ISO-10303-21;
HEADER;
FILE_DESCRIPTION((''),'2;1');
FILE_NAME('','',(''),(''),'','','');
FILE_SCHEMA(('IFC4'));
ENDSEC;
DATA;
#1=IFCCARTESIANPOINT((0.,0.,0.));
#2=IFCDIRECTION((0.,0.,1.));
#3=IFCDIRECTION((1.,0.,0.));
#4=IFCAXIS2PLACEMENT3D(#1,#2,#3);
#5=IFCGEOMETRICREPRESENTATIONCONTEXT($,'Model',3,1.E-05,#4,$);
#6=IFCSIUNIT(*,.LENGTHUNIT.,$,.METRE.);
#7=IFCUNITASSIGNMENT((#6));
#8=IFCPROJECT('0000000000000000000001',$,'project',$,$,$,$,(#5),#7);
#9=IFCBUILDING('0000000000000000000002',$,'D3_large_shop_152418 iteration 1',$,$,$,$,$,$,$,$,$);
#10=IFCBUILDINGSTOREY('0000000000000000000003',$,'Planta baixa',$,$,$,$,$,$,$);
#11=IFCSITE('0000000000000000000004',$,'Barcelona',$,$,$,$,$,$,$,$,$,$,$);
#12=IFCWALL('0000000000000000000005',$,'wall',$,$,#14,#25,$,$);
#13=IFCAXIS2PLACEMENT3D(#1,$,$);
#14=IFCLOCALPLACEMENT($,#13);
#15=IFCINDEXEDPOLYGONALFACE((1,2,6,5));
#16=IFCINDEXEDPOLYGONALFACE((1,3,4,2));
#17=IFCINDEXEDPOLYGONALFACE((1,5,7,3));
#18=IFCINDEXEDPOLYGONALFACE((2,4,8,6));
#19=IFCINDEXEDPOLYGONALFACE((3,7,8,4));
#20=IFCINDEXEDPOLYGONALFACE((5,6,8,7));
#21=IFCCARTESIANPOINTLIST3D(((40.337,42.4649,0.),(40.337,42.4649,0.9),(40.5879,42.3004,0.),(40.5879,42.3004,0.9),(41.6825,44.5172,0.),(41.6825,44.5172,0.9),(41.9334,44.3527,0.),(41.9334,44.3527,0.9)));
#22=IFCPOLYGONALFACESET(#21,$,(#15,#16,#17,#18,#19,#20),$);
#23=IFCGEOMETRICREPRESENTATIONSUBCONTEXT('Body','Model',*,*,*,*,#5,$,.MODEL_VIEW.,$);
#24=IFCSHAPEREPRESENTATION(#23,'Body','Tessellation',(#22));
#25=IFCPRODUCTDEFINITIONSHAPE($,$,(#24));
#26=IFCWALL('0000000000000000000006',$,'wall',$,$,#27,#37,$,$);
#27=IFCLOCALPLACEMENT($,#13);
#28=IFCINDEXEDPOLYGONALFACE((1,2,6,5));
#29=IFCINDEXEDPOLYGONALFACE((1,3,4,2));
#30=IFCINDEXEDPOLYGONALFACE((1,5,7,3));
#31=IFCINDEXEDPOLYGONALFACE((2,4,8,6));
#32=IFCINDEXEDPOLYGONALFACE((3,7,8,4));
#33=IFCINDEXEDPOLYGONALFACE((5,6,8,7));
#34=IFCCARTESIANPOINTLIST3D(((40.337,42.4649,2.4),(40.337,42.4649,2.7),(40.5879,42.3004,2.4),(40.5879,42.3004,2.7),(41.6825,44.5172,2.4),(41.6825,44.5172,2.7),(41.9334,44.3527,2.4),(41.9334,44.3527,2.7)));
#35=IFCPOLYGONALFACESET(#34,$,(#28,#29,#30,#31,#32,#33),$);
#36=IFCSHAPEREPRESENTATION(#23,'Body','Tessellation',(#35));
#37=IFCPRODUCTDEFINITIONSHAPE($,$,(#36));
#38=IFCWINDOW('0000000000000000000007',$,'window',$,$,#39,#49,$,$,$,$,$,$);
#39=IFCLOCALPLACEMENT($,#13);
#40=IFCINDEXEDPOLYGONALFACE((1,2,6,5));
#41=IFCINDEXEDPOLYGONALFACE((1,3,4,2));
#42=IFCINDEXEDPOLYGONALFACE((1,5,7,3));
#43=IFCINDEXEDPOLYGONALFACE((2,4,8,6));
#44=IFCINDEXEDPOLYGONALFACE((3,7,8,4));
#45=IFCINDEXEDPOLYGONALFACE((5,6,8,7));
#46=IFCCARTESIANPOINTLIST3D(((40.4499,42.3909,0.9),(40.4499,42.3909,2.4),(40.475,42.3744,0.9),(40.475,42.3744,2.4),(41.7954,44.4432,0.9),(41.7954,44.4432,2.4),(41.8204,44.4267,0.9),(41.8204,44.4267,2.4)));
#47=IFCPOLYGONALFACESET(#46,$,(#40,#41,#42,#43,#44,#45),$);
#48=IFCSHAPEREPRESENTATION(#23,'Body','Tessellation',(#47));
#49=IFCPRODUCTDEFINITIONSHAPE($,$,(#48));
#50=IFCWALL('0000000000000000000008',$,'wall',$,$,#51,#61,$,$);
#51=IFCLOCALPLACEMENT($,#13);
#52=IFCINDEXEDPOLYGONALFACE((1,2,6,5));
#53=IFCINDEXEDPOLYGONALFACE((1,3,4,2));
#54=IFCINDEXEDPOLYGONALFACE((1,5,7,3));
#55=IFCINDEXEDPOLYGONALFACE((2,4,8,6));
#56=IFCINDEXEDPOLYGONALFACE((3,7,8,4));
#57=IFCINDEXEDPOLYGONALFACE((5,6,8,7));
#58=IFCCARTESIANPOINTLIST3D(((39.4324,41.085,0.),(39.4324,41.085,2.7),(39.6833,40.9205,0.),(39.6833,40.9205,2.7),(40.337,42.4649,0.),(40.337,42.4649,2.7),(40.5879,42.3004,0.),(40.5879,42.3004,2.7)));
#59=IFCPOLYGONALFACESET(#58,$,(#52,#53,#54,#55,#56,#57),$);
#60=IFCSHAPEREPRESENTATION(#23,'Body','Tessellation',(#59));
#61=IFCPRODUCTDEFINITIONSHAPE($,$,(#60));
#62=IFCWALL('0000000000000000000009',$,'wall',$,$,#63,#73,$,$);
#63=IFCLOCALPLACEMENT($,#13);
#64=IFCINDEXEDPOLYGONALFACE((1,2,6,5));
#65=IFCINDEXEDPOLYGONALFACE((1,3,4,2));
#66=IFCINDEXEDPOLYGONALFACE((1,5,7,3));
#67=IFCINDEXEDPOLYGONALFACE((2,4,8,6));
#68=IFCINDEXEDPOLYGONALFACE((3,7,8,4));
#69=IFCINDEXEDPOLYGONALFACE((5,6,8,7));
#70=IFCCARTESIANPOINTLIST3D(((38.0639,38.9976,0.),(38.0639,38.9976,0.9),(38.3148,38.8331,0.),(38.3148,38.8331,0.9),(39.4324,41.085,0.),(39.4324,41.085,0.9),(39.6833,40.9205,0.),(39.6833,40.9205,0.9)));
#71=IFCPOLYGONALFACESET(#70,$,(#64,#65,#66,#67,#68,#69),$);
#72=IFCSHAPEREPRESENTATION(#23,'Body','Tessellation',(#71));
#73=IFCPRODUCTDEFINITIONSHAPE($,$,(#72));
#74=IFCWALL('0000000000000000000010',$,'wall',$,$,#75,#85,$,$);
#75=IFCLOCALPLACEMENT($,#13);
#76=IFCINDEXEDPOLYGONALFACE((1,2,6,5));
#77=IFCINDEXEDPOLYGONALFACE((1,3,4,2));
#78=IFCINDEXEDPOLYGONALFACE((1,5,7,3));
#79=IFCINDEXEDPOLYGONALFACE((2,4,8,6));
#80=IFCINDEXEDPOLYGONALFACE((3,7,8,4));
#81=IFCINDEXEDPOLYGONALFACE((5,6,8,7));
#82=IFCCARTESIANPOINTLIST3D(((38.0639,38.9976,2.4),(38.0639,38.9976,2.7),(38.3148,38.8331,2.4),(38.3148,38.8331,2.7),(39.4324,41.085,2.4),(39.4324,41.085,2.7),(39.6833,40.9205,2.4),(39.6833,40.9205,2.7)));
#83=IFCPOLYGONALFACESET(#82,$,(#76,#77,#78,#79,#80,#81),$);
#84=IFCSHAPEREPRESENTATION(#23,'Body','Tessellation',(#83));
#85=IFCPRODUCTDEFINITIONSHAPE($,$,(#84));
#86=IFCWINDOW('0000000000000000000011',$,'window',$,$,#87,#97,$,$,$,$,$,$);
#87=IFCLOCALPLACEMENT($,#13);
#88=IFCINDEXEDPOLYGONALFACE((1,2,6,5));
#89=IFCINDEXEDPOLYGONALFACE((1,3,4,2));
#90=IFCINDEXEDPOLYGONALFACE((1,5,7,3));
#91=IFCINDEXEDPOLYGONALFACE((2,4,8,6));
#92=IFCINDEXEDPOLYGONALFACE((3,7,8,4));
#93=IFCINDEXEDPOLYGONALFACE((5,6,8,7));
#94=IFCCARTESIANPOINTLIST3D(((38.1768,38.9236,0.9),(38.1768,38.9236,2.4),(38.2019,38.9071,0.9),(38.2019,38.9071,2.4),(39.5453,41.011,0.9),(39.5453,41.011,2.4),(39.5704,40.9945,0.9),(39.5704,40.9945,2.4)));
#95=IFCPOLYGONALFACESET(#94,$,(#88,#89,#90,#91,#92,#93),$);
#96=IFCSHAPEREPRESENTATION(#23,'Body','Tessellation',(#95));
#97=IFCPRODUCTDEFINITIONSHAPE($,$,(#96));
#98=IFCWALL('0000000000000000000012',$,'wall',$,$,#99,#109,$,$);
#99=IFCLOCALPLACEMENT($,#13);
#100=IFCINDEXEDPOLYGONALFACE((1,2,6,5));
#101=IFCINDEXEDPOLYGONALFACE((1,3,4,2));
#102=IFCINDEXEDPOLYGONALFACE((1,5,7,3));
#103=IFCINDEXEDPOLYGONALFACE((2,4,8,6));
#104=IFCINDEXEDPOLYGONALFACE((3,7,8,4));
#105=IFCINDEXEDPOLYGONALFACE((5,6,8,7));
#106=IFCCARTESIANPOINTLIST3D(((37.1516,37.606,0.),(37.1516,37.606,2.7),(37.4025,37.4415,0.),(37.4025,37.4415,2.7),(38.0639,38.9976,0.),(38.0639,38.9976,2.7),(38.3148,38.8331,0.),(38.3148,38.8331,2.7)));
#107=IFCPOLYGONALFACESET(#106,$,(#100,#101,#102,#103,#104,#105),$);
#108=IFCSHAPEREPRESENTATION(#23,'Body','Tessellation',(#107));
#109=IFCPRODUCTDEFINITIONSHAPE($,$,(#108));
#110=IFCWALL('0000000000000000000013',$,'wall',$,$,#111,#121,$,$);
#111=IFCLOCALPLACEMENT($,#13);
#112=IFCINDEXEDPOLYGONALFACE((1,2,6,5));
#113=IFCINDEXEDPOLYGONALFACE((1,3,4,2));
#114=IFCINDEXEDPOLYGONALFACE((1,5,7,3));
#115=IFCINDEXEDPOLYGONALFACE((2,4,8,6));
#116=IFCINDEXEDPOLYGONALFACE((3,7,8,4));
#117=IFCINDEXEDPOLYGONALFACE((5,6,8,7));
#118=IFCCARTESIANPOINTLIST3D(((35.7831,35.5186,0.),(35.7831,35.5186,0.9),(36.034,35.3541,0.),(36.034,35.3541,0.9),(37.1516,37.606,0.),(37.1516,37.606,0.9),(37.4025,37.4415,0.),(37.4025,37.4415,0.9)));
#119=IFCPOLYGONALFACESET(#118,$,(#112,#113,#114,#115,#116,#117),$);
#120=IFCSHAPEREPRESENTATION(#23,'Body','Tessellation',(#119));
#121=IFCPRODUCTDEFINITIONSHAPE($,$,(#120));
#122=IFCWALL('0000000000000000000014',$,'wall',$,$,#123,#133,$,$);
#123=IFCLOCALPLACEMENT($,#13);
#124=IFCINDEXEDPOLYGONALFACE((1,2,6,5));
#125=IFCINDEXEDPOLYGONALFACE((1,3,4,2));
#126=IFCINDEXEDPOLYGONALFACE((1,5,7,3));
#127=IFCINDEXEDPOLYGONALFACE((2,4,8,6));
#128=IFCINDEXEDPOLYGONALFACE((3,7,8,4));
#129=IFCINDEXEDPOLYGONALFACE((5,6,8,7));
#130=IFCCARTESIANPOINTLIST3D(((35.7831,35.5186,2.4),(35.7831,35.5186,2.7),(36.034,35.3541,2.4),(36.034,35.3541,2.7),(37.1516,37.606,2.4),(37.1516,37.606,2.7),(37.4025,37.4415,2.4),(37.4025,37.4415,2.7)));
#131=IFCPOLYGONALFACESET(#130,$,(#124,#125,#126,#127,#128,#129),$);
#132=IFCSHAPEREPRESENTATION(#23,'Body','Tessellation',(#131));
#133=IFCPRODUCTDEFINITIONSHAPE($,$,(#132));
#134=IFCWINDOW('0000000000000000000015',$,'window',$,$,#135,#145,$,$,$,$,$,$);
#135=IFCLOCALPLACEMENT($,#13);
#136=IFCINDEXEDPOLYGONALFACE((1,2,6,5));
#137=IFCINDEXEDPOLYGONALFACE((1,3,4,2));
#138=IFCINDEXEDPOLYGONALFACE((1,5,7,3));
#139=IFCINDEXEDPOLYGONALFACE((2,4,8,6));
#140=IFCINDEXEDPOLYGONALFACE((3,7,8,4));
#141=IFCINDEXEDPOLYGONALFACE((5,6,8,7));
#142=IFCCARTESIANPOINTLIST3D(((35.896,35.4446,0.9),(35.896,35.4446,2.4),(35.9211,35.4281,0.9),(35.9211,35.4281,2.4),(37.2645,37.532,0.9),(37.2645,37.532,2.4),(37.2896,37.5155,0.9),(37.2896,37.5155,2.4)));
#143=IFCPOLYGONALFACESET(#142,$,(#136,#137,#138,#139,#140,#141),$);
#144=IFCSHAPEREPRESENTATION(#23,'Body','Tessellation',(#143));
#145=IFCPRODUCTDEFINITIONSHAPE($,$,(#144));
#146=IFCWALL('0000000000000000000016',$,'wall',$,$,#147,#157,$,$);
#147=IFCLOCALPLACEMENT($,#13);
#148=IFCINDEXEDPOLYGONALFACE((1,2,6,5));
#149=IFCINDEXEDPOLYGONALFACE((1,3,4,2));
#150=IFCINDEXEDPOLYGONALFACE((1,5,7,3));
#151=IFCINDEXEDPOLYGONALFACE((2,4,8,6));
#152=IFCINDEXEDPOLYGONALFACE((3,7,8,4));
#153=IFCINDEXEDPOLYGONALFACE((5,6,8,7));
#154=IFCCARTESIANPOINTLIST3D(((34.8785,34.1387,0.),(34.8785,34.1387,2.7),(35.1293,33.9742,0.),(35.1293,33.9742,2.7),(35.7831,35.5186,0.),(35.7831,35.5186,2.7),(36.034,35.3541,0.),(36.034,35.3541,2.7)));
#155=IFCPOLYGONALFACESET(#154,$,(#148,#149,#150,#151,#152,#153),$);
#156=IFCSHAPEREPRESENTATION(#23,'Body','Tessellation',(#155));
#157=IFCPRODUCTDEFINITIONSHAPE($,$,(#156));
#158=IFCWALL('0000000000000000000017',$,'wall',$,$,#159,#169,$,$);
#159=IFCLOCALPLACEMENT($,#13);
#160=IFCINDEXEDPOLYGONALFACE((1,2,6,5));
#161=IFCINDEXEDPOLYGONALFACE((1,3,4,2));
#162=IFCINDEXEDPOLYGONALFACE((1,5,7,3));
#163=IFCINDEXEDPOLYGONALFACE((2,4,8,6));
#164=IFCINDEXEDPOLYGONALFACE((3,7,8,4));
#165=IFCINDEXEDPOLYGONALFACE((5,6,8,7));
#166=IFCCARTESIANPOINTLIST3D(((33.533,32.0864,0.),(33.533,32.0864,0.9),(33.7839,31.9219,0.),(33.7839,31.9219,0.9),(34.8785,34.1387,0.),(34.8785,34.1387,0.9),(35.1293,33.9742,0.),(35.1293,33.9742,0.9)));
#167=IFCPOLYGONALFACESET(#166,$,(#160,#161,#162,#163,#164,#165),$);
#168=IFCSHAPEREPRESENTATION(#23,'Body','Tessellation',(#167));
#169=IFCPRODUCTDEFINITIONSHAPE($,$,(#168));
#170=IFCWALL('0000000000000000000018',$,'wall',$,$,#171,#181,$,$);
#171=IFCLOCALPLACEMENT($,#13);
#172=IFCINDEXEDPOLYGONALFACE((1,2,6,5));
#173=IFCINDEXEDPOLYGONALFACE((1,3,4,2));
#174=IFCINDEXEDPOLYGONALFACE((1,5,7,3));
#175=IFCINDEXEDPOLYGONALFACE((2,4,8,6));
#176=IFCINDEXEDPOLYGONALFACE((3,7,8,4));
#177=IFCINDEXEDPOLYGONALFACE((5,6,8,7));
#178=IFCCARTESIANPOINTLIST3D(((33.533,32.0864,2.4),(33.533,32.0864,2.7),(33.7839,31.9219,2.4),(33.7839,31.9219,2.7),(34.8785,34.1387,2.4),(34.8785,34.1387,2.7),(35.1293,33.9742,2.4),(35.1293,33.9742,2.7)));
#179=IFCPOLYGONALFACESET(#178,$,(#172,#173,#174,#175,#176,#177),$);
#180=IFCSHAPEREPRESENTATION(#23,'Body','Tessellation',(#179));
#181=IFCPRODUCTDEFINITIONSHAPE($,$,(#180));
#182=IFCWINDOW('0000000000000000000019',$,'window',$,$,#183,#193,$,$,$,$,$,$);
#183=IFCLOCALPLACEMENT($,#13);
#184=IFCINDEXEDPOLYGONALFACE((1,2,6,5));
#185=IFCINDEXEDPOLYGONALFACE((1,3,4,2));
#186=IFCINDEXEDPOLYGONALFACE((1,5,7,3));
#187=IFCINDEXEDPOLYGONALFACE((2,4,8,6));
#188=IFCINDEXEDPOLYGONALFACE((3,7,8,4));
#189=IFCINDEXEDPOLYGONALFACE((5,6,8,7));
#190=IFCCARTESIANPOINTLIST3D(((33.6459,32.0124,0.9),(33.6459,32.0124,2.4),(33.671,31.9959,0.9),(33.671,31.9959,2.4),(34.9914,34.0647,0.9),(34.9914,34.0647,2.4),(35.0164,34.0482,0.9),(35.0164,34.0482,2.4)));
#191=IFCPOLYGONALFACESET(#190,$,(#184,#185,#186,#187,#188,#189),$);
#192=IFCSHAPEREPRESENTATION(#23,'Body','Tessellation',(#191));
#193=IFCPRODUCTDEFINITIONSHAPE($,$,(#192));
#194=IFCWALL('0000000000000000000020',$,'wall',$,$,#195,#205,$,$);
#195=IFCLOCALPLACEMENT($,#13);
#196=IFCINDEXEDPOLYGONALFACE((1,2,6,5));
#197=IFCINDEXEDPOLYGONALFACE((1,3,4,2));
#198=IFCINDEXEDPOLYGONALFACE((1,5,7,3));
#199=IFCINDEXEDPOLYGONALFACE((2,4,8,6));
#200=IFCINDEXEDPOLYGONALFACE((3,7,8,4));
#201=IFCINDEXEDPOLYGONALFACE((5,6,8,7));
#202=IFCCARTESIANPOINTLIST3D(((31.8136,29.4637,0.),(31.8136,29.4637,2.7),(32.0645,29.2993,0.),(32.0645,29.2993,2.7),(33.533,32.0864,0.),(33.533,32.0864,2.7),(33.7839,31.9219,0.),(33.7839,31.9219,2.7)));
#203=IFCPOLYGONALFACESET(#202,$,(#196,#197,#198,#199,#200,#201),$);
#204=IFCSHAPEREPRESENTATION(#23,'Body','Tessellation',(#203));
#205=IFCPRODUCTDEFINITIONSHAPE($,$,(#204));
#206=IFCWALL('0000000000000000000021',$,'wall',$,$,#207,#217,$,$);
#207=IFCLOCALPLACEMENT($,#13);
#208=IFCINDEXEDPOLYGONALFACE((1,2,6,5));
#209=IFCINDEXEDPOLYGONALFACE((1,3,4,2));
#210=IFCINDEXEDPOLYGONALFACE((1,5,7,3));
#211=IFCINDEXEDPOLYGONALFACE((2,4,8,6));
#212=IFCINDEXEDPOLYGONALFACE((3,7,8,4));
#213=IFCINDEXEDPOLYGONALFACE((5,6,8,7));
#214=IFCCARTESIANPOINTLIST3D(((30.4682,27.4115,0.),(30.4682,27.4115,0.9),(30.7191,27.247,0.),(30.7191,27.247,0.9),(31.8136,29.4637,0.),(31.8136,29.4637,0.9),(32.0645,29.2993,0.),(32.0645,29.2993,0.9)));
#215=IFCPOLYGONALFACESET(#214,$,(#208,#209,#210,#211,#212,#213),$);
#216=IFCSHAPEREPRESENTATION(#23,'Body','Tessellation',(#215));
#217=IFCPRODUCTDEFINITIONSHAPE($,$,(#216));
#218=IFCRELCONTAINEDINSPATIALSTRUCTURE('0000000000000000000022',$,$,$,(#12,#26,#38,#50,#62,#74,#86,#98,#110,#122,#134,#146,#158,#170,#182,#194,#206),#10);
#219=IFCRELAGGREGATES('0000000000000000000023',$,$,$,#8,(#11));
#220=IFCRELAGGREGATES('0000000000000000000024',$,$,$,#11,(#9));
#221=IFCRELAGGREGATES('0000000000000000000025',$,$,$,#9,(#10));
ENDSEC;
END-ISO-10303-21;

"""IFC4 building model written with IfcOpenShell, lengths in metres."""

from ifc_helpers import new_model, si_unit, frame, origin, origin_with_axes, place, context, subcontext, project, spatial, polyline, outline, extrude, element, save


model = new_model("IFC4")

# Units and contexts
model_context = context("Model", 3, precision=1e-05, world=origin_with_axes())
body_context = subcontext(model_context, "Body", "Model", "MODEL_VIEW")
ifc_project = project(units=[si_unit("LENGTHUNIT", "METRE")], contexts=[model_context])

# Site, building, storey
site = spatial("IfcSite", under=ifc_project, Name="Barcelona")
building = spatial("IfcBuilding", under=site, Name="D3_large_shop_152418 iteration 1")
storey = spatial("IfcBuildingStorey", under=building, Name="Planta baixa")

# Walls
wall_1_placement = place(None, origin_with_axes())
element("IfcWall", 1, at=wall_1_placement, inside=storey, Name="wall", context=body_context, shape_type="SweptSolid", body=[
    extrude(outline(polyline([(41.9334, 44.3527), (40.5879, 42.3004), (40.337, 42.4649), (41.6825, 44.5172), (41.9334, 44.3527)])), origin(), (0.0, 0.0, 1.0), 0.9),
])
wall_2_placement = place(None, origin_with_axes())
element("IfcWall", 2, at=wall_2_placement, inside=storey, Name="wall", context=body_context, shape_type="SweptSolid", body=[
    extrude(outline(polyline([(41.9334, 44.3527), (40.5879, 42.3004), (40.337, 42.4649), (41.6825, 44.5172), (41.9334, 44.3527)])), frame((0.0, 0.0, 2.4)), (0.0, 0.0, 1.0), 0.3),
])

# Window
window_1_placement = place(None, origin_with_axes())
element("IfcWindow", 3, at=window_1_placement, inside=storey, Name="window", context=body_context, shape_type="SweptSolid", body=[
    extrude(outline(polyline([(41.8204, 44.4267), (40.475, 42.3744), (40.4499, 42.3909), (41.7954, 44.4432), (41.8204, 44.4267)])), frame((0.0, 0.0, 0.9)), (0.0, 0.0, 1.0), 1.5),
])

# Walls
wall_3_placement = place(None, origin_with_axes())
element("IfcWall", 4, at=wall_3_placement, inside=storey, Name="wall", context=body_context, shape_type="SweptSolid", body=[
    extrude(outline(polyline([(40.5879, 42.3004), (39.6833, 40.9205), (39.4324, 41.085), (40.337, 42.4649), (40.5879, 42.3004)])), origin(), (0.0, 0.0, 1.0), 2.7),
])
wall_4_placement = place(None, origin_with_axes())
element("IfcWall", 5, at=wall_4_placement, inside=storey, Name="wall", context=body_context, shape_type="SweptSolid", body=[
    extrude(outline(polyline([(39.6833, 40.9205), (38.3148, 38.8331), (38.0639, 38.9976), (39.4324, 41.085), (39.6833, 40.9205)])), origin(), (0.0, 0.0, 1.0), 0.9),
])
wall_5_placement = place(None, origin_with_axes())
element("IfcWall", 6, at=wall_5_placement, inside=storey, Name="wall", context=body_context, shape_type="SweptSolid", body=[
    extrude(outline(polyline([(39.6833, 40.9205), (38.3148, 38.8331), (38.0639, 38.9976), (39.4324, 41.085), (39.6833, 40.9205)])), frame((0.0, 0.0, 2.4)), (0.0, 0.0, 1.0), 0.3),
])

# Window
window_2_placement = place(None, origin_with_axes())
element("IfcWindow", 7, at=window_2_placement, inside=storey, Name="window", context=body_context, shape_type="SweptSolid", body=[
    extrude(outline(polyline([(39.5704, 40.9945), (38.2019, 38.9071), (38.1768, 38.9236), (39.5453, 41.011), (39.5704, 40.9945)])), frame((0.0, 0.0, 0.9)), (0.0, 0.0, 1.0), 1.5),
])

# Walls
wall_6_placement = place(None, origin_with_axes())
element("IfcWall", 8, at=wall_6_placement, inside=storey, Name="wall", context=body_context, shape_type="SweptSolid", body=[
    extrude(outline(polyline([(38.3148, 38.8331), (37.4025, 37.4415), (37.1516, 37.606), (38.0639, 38.9976), (38.3148, 38.8331)])), origin(), (0.0, 0.0, 1.0), 2.7),
])
wall_7_placement = place(None, origin_with_axes())
element("IfcWall", 9, at=wall_7_placement, inside=storey, Name="wall", context=body_context, shape_type="SweptSolid", body=[
    extrude(outline(polyline([(37.4025, 37.4415), (36.034, 35.3541), (35.7831, 35.5186), (37.1516, 37.606), (37.4025, 37.4415)])), origin(), (0.0, 0.0, 1.0), 0.9),
])
wall_8_placement = place(None, origin_with_axes())
element("IfcWall", 10, at=wall_8_placement, inside=storey, Name="wall", context=body_context, shape_type="SweptSolid", body=[
    extrude(outline(polyline([(37.4025, 37.4415), (36.034, 35.3541), (35.7831, 35.5186), (37.1516, 37.606), (37.4025, 37.4415)])), frame((0.0, 0.0, 2.4)), (0.0, 0.0, 1.0), 0.3),
])

# Window
window_3_placement = place(None, origin_with_axes())
element("IfcWindow", 11, at=window_3_placement, inside=storey, Name="window", context=body_context, shape_type="SweptSolid", body=[
    extrude(outline(polyline([(37.2896, 37.5155), (35.9211, 35.4281), (35.896, 35.4446), (37.2645, 37.532), (37.2896, 37.5155)])), frame((0.0, 0.0, 0.9)), (0.0, 0.0, 1.0), 1.5),
])

# Walls
wall_9_placement = place(None, origin_with_axes())
element("IfcWall", 12, at=wall_9_placement, inside=storey, Name="wall", context=body_context, shape_type="SweptSolid", body=[
    extrude(outline(polyline([(36.034, 35.3541), (35.1293, 33.9742), (34.8785, 34.1387), (35.7831, 35.5186), (36.034, 35.3541)])), origin(), (0.0, 0.0, 1.0), 2.7),
])
wall_10_placement = place(None, origin_with_axes())
element("IfcWall", 13, at=wall_10_placement, inside=storey, Name="wall", context=body_context, shape_type="SweptSolid", body=[
    extrude(outline(polyline([(35.1293, 33.9742), (33.7839, 31.9219), (33.533, 32.0864), (34.8785, 34.1387), (35.1293, 33.9742)])), origin(), (0.0, 0.0, 1.0), 0.9),
])
wall_11_placement = place(None, origin_with_axes())
element("IfcWall", 14, at=wall_11_placement, inside=storey, Name="wall", context=body_context, shape_type="SweptSolid", body=[
    extrude(outline(polyline([(35.1293, 33.9742), (33.7839, 31.9219), (33.533, 32.0864), (34.8785, 34.1387), (35.1293, 33.9742)])), frame((0.0, 0.0, 2.4)), (0.0, 0.0, 1.0), 0.3),
])

# Window
window_4_placement = place(None, origin_with_axes())
element("IfcWindow", 15, at=window_4_placement, inside=storey, Name="window", context=body_context, shape_type="SweptSolid", body=[
    extrude(outline(polyline([(35.0164, 34.0482), (33.671, 31.9959), (33.6459, 32.0124), (34.9914, 34.0647), (35.0164, 34.0482)])), frame((0.0, 0.0, 0.9)), (0.0, 0.0, 1.0), 1.5),
])

# Walls
wall_12_placement = place(None, origin_with_axes())
element("IfcWall", 16, at=wall_12_placement, inside=storey, Name="wall", context=body_context, shape_type="SweptSolid", body=[
    extrude(outline(polyline([(33.7839, 31.9219), (32.0645, 29.2993), (31.8136, 29.4637), (33.533, 32.0864), (33.7839, 31.9219)])), origin(), (0.0, 0.0, 1.0), 2.7),
])
wall_13_placement = place(None, origin_with_axes())
element("IfcWall", 17, at=wall_13_placement, inside=storey, Name="wall", context=body_context, shape_type="SweptSolid", body=[
    extrude(outline(polyline([(32.0645, 29.2993), (30.7191, 27.247), (30.4682, 27.4115), (31.8136, 29.4637), (32.0645, 29.2993)])), origin(), (0.0, 0.0, 1.0), 0.9),
])

save(model, "model.ifc")
